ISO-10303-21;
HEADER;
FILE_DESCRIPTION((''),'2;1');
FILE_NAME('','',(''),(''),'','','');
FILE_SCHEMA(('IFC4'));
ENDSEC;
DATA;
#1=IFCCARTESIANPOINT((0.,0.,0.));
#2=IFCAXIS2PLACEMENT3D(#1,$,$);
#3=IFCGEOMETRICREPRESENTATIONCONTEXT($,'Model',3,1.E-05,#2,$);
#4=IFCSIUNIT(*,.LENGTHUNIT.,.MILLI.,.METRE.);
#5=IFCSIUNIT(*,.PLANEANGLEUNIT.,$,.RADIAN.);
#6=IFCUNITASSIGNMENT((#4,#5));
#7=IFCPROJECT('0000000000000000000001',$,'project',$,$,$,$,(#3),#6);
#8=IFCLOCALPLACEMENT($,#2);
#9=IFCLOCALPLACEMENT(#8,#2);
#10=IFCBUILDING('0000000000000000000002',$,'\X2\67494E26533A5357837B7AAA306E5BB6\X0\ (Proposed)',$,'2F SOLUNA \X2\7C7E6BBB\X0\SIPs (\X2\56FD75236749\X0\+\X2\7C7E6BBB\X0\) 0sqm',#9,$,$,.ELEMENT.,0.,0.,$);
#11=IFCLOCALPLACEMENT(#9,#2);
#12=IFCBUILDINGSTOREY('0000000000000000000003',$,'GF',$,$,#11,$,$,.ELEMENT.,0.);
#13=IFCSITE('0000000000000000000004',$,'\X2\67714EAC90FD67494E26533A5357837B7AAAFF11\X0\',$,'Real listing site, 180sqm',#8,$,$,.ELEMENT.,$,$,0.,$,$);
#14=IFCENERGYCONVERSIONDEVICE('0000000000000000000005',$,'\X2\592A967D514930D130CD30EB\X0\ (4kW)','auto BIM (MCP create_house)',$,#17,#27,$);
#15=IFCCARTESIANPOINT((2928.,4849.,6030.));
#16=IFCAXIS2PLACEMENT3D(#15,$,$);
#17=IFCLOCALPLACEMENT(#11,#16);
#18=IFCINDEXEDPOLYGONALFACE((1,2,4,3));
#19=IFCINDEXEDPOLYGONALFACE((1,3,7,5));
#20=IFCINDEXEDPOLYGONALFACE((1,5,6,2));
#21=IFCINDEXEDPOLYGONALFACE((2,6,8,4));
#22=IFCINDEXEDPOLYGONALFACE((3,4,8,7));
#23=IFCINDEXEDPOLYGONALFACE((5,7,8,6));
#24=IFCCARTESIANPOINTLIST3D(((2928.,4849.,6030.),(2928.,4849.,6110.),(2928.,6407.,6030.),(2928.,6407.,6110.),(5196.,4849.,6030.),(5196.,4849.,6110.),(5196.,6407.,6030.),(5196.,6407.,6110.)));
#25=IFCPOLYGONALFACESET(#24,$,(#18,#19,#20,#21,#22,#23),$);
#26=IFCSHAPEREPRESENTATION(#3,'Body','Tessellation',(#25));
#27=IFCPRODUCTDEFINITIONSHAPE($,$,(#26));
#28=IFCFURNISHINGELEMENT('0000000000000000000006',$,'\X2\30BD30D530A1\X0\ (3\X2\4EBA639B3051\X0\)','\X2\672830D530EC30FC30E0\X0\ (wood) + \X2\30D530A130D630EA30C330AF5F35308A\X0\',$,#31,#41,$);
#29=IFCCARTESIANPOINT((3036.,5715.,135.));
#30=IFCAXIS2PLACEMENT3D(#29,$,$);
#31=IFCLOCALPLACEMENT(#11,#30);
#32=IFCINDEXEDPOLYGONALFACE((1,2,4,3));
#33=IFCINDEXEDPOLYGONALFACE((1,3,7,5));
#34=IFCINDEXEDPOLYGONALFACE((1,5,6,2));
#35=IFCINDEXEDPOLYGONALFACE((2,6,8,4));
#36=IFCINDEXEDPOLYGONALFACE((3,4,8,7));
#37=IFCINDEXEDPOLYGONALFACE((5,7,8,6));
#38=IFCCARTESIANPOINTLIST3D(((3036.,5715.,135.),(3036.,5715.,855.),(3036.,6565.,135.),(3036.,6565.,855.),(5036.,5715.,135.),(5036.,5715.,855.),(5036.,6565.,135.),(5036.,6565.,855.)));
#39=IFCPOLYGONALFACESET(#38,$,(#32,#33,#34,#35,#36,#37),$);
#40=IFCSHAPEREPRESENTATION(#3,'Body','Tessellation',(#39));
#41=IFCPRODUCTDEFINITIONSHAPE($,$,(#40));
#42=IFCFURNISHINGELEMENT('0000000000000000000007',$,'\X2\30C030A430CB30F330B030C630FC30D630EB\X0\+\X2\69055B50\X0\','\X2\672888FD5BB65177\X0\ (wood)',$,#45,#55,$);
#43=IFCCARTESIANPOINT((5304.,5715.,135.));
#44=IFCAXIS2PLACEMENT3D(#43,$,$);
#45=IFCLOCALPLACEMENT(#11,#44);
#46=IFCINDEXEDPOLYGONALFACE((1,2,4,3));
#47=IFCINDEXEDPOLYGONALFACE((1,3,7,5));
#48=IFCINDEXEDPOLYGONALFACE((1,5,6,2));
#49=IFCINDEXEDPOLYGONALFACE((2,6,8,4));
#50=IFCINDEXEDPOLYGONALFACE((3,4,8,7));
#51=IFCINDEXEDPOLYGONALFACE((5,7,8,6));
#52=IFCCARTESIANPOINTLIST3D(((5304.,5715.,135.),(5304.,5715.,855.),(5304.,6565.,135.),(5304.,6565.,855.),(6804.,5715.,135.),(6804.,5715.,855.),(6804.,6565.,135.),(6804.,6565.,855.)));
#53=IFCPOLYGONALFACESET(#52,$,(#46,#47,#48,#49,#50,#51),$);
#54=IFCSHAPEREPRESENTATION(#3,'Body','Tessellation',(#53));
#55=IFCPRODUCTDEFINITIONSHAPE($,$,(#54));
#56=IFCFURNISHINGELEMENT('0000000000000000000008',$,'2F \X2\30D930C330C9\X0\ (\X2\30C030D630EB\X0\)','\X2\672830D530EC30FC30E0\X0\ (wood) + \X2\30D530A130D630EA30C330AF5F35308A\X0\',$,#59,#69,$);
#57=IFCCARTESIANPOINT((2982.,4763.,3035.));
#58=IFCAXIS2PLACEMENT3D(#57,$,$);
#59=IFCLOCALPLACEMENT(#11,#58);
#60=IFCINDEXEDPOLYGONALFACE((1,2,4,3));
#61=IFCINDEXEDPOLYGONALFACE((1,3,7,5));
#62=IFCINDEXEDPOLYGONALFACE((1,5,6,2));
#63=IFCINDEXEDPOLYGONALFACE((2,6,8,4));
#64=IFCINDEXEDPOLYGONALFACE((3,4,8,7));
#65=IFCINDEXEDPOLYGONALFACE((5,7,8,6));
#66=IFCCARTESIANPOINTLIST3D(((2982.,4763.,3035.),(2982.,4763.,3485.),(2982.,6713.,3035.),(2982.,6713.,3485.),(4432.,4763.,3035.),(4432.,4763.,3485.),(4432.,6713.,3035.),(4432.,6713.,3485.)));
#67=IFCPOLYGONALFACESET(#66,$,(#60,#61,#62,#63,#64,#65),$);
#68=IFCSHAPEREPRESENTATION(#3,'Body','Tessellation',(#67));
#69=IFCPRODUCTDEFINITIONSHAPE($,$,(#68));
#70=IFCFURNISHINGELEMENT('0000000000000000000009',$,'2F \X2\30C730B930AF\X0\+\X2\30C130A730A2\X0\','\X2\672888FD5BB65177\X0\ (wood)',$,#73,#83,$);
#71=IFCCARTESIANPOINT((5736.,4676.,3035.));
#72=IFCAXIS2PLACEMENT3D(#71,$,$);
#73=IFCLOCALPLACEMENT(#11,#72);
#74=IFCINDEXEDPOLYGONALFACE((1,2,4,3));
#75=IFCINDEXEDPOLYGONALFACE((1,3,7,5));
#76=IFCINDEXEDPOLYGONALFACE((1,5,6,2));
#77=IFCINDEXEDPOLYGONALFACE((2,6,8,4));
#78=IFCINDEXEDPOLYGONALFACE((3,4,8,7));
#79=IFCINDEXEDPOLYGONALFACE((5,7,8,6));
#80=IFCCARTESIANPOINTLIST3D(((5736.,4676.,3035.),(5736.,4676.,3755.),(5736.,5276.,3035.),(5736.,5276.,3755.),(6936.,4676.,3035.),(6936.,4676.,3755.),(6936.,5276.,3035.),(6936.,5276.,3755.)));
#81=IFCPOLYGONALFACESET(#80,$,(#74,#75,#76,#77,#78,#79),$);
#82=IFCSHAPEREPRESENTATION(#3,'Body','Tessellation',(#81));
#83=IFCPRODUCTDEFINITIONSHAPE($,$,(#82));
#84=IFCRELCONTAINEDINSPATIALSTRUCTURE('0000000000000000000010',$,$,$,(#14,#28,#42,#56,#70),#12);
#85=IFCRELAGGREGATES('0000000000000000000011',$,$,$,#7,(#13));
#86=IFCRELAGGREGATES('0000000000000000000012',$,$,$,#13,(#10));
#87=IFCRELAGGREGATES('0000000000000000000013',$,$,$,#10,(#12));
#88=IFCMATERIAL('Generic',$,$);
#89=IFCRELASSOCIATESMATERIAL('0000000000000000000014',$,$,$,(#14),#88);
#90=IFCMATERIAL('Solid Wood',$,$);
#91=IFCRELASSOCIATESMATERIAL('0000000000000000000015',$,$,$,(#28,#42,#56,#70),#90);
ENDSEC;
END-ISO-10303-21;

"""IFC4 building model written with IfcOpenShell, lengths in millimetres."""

from ifc_helpers import new_model, si_unit, frame, frame_2d, origin, place, context, project, spatial, rectangle, extrude, material, element, save


model = new_model("IFC4")

# Units and contexts
model_context = context("Model", 3, precision=1e-05, world=origin())
ifc_project = project(units=[si_unit("LENGTHUNIT", "METRE", prefix="MILLI"), si_unit("PLANEANGLEUNIT", "RADIAN")], contexts=[model_context])

# Site, building, storey
site_placement = place(None, origin())
site = spatial("IfcSite", under=ifc_project, at=site_placement, Name="東京都杉並区南荻窪１", ObjectType="Real listing site, 180sqm", CompositionType="ELEMENT", RefElevation=0.0)
building_placement = place(site_placement, origin())
building = spatial("IfcBuilding", under=site, at=building_placement, Name="杉並区南荻窪の家 (Proposed)", ObjectType="2F SOLUNA 籾殻SIPs (国産杉+籾殻) 0sqm", CompositionType="ELEMENT", ElevationOfRefHeight=0.0, ElevationOfTerrain=0.0)
storey_placement = place(building_placement, origin())
storey = spatial("IfcBuildingStorey", under=building, at=storey_placement, Name="GF", CompositionType="ELEMENT", Elevation=0.0)

# Shared definitions
ifc_material_1 = material(Name="Solid Wood")

# Shared definitions
ifc_material_2 = material(Name="Generic")

# Energy conversion device
energy_conversion_device_placement = place(storey_placement, frame((2928.0, 4849.0, 6030.0)))
element("IfcEnergyConversionDevice", 1, at=energy_conversion_device_placement, inside=storey, material=ifc_material_2, Name="太陽光パネル (4kW)", Description="auto BIM (MCP create_house)", context=model_context, shape_type="SweptSolid", body=[
    extrude(rectangle(XDim=2268.0, YDim=1558.0, at=frame_2d((1134.0, 779.0))), frame((2928.0, 4849.0, 6030.0)), (0.0, 0.0, 1.0), 80.0),
])

# Furnishing elements
furnishing_1_placement = place(storey_placement, frame((3036.0, 5715.0, 135.0)))
element("IfcFurnishingElement", 2, at=furnishing_1_placement, inside=storey, material=ifc_material_1, Name="ソファ (3人掛け)", Description="木フレーム (wood) + ファブリック張り", context=model_context, shape_type="SweptSolid", body=[
    extrude(rectangle(XDim=2000.0, YDim=850.0, at=frame_2d((1000.0, 425.0))), frame((3036.0, 5715.0, 135.0)), (0.0, 0.0, 1.0), 720.0),
])
furnishing_2_placement = place(storey_placement, frame((5304.0, 5715.0, 135.0)))
element("IfcFurnishingElement", 3, at=furnishing_2_placement, inside=storey, material=ifc_material_1, Name="ダイニングテーブル+椅子", Description="木製家具 (wood)", context=model_context, shape_type="SweptSolid", body=[
    extrude(rectangle(XDim=1500.0, YDim=850.0, at=frame_2d((750.0, 425.0))), frame((5304.0, 5715.0, 135.0)), (0.0, 0.0, 1.0), 720.0),
])
furnishing_3_placement = place(storey_placement, frame((2982.0, 4763.0, 3035.0)))
element("IfcFurnishingElement", 4, at=furnishing_3_placement, inside=storey, material=ifc_material_1, Name="2F ベッド (ダブル)", Description="木フレーム (wood) + ファブリック張り", context=model_context, shape_type="SweptSolid", body=[
    extrude(rectangle(XDim=1450.0, YDim=1950.0, at=frame_2d((725.0, 975.0))), frame((2982.0, 4763.0, 3035.0)), (0.0, 0.0, 1.0), 450.0),
])
furnishing_4_placement = place(storey_placement, frame((5736.0, 4676.0, 3035.0)))
element("IfcFurnishingElement", 5, at=furnishing_4_placement, inside=storey, material=ifc_material_1, Name="2F デスク+チェア", Description="木製家具 (wood)", context=model_context, shape_type="SweptSolid", body=[
    extrude(rectangle(XDim=1200.0, YDim=600.0, at=frame_2d((600.0, 300.0))), frame((5736.0, 4676.0, 3035.0)), (0.0, 0.0, 1.0), 720.0),
])

save(model, "model.ifc")
